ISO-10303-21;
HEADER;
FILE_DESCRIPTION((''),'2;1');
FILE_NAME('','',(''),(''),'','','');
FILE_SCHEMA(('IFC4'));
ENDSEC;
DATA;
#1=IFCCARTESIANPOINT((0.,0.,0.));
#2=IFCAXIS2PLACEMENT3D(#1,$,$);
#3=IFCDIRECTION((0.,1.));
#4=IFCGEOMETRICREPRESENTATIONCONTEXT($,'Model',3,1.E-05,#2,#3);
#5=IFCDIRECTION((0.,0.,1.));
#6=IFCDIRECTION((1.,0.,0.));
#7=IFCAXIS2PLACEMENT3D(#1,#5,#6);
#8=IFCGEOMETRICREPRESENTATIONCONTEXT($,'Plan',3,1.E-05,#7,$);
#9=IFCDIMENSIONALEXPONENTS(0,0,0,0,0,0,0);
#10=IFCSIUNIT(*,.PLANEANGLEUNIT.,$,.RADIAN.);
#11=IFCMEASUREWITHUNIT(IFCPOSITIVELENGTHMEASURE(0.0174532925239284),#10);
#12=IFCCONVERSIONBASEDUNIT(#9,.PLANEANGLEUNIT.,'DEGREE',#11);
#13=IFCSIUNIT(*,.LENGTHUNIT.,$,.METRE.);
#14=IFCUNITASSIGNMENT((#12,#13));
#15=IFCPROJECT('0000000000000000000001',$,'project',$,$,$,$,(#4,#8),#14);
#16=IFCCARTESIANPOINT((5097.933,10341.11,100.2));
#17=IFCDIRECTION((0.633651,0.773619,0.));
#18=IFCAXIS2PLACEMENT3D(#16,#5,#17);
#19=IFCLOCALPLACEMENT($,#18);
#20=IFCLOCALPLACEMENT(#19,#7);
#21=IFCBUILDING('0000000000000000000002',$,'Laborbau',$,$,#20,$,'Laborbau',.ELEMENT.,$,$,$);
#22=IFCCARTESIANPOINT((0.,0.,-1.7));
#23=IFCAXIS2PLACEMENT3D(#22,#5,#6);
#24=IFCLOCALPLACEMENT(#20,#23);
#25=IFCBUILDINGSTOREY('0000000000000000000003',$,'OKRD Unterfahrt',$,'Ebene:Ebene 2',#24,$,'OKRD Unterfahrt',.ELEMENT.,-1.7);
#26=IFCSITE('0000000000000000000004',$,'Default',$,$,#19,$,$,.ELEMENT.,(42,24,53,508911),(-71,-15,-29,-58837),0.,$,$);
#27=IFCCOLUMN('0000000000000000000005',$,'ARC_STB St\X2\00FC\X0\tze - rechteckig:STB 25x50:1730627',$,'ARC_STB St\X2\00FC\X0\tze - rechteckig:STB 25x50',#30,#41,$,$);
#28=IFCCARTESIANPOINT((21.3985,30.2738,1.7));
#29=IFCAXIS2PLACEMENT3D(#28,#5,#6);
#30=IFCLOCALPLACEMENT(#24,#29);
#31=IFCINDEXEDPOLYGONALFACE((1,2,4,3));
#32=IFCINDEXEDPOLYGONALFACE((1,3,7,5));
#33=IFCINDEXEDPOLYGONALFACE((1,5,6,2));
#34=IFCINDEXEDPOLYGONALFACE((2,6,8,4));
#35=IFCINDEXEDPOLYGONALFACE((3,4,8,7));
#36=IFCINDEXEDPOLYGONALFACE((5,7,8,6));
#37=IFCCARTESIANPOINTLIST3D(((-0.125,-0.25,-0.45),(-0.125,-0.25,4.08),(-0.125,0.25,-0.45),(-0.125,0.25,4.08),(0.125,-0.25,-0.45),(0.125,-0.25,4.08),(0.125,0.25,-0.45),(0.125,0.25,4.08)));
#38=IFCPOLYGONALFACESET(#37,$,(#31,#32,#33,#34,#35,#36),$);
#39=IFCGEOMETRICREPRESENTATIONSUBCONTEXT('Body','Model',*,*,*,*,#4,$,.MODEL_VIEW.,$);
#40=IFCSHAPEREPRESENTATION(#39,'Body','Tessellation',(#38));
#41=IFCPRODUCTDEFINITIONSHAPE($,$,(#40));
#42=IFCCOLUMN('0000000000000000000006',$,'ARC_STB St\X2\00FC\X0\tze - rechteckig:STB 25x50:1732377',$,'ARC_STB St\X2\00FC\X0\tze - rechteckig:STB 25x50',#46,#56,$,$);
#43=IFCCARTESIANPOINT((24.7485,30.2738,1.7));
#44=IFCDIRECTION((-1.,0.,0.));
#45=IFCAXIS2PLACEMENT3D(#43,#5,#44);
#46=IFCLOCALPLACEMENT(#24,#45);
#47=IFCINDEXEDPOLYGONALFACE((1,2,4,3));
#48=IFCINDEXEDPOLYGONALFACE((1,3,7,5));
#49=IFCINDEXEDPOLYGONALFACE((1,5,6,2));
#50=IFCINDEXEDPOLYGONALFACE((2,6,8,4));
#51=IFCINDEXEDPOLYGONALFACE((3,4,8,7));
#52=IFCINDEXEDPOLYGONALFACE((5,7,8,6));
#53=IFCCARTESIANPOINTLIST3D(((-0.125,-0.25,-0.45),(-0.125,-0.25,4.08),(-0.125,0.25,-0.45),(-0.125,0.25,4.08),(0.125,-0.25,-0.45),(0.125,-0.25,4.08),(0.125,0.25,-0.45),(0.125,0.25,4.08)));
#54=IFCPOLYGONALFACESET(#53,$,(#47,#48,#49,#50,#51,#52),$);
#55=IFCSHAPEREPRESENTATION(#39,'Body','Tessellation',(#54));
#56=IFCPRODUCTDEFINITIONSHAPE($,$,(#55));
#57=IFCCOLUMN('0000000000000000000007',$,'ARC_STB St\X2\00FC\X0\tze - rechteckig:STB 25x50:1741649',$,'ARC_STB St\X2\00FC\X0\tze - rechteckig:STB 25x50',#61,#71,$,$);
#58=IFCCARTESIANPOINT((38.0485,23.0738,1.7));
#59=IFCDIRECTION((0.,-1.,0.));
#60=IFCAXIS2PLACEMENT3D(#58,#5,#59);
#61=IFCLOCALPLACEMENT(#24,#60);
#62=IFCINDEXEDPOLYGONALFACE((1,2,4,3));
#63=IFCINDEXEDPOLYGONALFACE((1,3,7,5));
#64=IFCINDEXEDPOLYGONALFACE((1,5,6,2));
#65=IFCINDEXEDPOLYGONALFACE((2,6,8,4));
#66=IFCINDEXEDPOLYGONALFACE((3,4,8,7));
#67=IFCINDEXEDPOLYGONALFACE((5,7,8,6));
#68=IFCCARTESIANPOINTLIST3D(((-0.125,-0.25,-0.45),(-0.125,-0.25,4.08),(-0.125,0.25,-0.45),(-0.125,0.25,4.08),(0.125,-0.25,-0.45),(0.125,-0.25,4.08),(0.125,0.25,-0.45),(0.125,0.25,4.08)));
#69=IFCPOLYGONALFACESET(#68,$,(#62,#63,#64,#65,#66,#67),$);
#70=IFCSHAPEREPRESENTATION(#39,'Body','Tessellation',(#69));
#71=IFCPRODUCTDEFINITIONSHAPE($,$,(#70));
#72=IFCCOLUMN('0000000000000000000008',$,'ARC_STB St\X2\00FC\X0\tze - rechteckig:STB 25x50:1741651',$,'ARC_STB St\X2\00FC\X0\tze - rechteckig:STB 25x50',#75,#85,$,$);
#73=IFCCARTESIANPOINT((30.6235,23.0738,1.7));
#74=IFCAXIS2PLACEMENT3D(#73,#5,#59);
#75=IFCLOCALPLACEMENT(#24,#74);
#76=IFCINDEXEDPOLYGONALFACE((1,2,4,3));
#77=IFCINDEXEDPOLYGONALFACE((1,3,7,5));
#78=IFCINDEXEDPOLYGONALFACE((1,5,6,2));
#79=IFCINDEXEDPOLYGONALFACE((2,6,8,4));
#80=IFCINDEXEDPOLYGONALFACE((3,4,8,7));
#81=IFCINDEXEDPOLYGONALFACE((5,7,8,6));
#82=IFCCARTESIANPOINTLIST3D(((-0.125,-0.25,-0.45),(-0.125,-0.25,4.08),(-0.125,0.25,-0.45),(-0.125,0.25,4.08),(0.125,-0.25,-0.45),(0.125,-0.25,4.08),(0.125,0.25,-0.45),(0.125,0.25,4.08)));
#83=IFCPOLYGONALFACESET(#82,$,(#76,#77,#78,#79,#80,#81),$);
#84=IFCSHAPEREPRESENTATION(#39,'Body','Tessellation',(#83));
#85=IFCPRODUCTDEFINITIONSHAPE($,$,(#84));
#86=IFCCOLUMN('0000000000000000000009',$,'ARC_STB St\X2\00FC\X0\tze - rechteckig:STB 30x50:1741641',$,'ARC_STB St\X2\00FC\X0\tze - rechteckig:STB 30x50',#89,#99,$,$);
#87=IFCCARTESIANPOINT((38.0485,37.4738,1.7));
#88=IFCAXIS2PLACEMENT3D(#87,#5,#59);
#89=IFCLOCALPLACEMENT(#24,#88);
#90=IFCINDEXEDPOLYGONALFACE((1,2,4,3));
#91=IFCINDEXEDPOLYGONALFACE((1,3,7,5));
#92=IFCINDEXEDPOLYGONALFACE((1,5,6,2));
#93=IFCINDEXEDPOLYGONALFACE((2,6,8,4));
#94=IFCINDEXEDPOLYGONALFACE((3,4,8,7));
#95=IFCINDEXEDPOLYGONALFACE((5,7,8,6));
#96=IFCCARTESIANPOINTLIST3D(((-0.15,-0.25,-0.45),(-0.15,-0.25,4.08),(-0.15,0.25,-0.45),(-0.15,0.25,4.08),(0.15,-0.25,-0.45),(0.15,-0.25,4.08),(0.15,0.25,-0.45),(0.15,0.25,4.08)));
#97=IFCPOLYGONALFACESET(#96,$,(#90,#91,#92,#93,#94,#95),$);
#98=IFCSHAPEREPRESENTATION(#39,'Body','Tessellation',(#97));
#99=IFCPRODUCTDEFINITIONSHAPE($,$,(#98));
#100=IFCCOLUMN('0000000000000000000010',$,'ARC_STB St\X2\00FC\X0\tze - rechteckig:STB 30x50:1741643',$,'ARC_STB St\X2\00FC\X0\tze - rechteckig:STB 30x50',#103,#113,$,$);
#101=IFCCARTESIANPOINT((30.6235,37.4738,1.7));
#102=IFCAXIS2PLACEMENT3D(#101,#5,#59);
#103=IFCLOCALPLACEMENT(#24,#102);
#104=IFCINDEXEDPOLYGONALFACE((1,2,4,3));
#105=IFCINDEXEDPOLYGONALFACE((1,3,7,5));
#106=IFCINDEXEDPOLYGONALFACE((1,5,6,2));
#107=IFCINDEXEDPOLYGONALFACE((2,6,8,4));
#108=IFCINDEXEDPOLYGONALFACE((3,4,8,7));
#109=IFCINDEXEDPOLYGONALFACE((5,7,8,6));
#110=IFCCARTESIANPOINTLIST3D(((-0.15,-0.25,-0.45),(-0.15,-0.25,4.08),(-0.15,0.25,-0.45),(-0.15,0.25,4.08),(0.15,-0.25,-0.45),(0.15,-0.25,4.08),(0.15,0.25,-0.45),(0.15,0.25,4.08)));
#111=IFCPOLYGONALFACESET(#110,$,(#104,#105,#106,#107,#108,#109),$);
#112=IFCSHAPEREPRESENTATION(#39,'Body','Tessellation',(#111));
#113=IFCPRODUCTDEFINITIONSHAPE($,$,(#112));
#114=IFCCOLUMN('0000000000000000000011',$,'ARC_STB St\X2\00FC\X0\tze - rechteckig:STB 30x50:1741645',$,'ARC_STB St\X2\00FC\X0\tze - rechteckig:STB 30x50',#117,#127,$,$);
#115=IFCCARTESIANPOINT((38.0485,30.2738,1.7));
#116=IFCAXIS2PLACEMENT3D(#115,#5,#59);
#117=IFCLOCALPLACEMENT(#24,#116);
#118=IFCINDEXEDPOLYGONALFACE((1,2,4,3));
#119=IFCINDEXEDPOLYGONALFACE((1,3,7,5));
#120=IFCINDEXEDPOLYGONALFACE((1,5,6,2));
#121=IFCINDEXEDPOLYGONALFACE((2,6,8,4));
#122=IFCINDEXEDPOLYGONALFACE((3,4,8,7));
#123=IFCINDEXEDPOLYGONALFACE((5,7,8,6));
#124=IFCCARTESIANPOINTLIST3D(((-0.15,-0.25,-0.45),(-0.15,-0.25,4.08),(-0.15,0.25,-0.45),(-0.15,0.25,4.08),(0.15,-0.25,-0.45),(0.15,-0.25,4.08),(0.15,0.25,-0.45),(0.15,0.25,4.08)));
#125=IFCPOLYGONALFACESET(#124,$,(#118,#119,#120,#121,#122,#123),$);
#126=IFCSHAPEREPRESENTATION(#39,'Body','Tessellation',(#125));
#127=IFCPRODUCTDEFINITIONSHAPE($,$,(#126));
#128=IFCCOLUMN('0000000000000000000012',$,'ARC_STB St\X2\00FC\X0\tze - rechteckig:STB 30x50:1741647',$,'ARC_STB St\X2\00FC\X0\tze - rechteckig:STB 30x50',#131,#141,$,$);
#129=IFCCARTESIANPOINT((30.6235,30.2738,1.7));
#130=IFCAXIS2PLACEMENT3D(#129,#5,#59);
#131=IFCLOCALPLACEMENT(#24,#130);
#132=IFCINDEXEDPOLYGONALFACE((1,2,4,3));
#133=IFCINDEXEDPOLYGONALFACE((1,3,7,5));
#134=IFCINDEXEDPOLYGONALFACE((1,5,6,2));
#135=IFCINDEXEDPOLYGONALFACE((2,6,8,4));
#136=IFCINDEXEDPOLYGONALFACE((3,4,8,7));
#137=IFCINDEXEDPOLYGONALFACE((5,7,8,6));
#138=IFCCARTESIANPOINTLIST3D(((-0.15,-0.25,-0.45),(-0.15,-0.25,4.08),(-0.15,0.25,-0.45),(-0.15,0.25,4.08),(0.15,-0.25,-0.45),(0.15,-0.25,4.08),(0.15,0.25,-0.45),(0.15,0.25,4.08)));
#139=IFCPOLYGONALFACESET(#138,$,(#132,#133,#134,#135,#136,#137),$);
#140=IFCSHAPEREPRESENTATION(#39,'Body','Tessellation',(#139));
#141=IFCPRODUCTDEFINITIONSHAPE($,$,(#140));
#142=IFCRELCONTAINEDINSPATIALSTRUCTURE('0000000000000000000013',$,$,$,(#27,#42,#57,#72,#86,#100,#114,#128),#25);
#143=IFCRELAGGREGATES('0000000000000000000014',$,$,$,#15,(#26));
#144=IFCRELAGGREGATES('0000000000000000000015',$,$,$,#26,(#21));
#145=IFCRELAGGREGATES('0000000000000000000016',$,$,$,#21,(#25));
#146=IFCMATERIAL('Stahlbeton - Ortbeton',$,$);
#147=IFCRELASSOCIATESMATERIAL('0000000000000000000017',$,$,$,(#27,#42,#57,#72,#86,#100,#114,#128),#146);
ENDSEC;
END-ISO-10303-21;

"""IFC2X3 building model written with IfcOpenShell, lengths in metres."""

from ifc_helpers import new_model, entity, si_unit, converted_unit, direction, frame, origin, origin_with_axes, origin_2d_with_axis, place, context, subcontext, project, spatial, rectangle, extrude, source, transform, mapped, material, element, save


model = new_model("IFC2X3")

# Units and contexts
model_context = context("Model", 3, precision=1e-05, world=origin(), true_north=direction((0.0, 1.0)))
plan_context = context("Plan", 3, precision=1e-05, world=origin_with_axes())
body_context = subcontext(model_context, "Body", "Model", "MODEL_VIEW")
ifc_project = project(units=[converted_unit("PLANEANGLEUNIT", "DEGREE", entity("IfcPositiveLengthMeasure", 0.0174532925239284), si_unit("PLANEANGLEUNIT", "RADIAN"), dimensions=[0, 0, 0, 0, 0, 0, 0]), si_unit("LENGTHUNIT", "METRE")], contexts=[model_context, plan_context])

# Site, building, storey
site_placement = place(None, frame((5097.933, 10341.11, 100.2), z_axis=(0.0, 0.0, 1.0), x_axis=(0.633651, 0.773619, 0.0)))
site = spatial("IfcSite", under=ifc_project, at=site_placement, Name="Default", CompositionType="ELEMENT", RefLatitude=(42, 24, 53, 508911), RefLongitude=(-71, -15, -29, -58837), RefElevation=0.0)
building_placement = place(site_placement, origin_with_axes())
building = spatial("IfcBuilding", under=site, at=building_placement, Name="Laborbau", LongName="Laborbau", CompositionType="ELEMENT")
storey_placement = place(building_placement, frame((0.0, 0.0, -1.7), z_axis=(0.0, 0.0, 1.0), x_axis=(1.0, 0.0, 0.0)))
storey = spatial("IfcBuildingStorey", under=building, at=storey_placement, Name="OKRD Unterfahrt", ObjectType="Ebene:Ebene 2", LongName="OKRD Unterfahrt", CompositionType="ELEMENT", Elevation=-1.7)

# Columns
ifc_material_1 = material(Name="Stahlbeton - Ortbeton")
shared_shape_1 = source(origin(), body_context, "Body", "SweptSolid", [
    extrude(rectangle(XDim=0.5, YDim=0.25, at=origin_2d_with_axis()), frame((0.0, 0.0, -0.45), z_axis=(0.0, 0.0, 1.0), x_axis=(0.0, -1.0, 0.0)), (0.0, 0.0, 1.0), 4.53),
])
for number, where, z_axis, x_axis, name in (
    (1, (21.3985, 30.2738, 1.7), (0.0, 0.0, 1.0), (1.0, 0.0, 0.0), "ARC_STB Stütze - rechteckig:STB 25x50:1730627"),
    (2, (24.7485, 30.2738, 1.7), (0.0, 0.0, 1.0), (-1.0, 0.0, 0.0), "ARC_STB Stütze - rechteckig:STB 25x50:1732377"),
    (3, (38.0485, 23.0738, 1.7), (0.0, 0.0, 1.0), (0.0, -1.0, 0.0), "ARC_STB Stütze - rechteckig:STB 25x50:1741649"),
    (4, (30.6235, 23.0738, 1.7), (0.0, 0.0, 1.0), (0.0, -1.0, 0.0), "ARC_STB Stütze - rechteckig:STB 25x50:1741651"),
):
    element("IfcColumn", number, at=place(storey_placement, frame(where, z_axis=z_axis, x_axis=x_axis)), inside=storey, material=ifc_material_1, Name=name, ObjectType="ARC_STB Stütze - rechteckig:STB 25x50", context=body_context, shape_type="MappedRepresentation", body=[
        mapped(shared_shape_1, transform((0.0, 0.0, 0.0), scale=1.0)),
    ])
shared_shape_2 = source(origin(), body_context, "Body", "SweptSolid", [
    extrude(rectangle(XDim=0.5, YDim=0.3, at=origin_2d_with_axis()), frame((0.0, 0.0, -0.45), z_axis=(0.0, 0.0, 1.0), x_axis=(0.0, -1.0, 0.0)), (0.0, 0.0, 1.0), 4.53),
])
for number, where, z_axis, x_axis, name in (
    (5, (38.0485, 37.4738, 1.7), (0.0, 0.0, 1.0), (0.0, -1.0, 0.0), "ARC_STB Stütze - rechteckig:STB 30x50:1741641"),
    (6, (30.6235, 37.4738, 1.7), (0.0, 0.0, 1.0), (0.0, -1.0, 0.0), "ARC_STB Stütze - rechteckig:STB 30x50:1741643"),
    (7, (38.0485, 30.2738, 1.7), (0.0, 0.0, 1.0), (0.0, -1.0, 0.0), "ARC_STB Stütze - rechteckig:STB 30x50:1741645"),
    (8, (30.6235, 30.2738, 1.7), (0.0, 0.0, 1.0), (0.0, -1.0, 0.0), "ARC_STB Stütze - rechteckig:STB 30x50:1741647"),
):
    element("IfcColumn", number, at=place(storey_placement, frame(where, z_axis=z_axis, x_axis=x_axis)), inside=storey, material=ifc_material_1, Name=name, ObjectType="ARC_STB Stütze - rechteckig:STB 30x50", context=body_context, shape_type="MappedRepresentation", body=[
        mapped(shared_shape_2, transform((0.0, 0.0, 0.0), scale=1.0)),
    ])

save(model, "model.ifc")
